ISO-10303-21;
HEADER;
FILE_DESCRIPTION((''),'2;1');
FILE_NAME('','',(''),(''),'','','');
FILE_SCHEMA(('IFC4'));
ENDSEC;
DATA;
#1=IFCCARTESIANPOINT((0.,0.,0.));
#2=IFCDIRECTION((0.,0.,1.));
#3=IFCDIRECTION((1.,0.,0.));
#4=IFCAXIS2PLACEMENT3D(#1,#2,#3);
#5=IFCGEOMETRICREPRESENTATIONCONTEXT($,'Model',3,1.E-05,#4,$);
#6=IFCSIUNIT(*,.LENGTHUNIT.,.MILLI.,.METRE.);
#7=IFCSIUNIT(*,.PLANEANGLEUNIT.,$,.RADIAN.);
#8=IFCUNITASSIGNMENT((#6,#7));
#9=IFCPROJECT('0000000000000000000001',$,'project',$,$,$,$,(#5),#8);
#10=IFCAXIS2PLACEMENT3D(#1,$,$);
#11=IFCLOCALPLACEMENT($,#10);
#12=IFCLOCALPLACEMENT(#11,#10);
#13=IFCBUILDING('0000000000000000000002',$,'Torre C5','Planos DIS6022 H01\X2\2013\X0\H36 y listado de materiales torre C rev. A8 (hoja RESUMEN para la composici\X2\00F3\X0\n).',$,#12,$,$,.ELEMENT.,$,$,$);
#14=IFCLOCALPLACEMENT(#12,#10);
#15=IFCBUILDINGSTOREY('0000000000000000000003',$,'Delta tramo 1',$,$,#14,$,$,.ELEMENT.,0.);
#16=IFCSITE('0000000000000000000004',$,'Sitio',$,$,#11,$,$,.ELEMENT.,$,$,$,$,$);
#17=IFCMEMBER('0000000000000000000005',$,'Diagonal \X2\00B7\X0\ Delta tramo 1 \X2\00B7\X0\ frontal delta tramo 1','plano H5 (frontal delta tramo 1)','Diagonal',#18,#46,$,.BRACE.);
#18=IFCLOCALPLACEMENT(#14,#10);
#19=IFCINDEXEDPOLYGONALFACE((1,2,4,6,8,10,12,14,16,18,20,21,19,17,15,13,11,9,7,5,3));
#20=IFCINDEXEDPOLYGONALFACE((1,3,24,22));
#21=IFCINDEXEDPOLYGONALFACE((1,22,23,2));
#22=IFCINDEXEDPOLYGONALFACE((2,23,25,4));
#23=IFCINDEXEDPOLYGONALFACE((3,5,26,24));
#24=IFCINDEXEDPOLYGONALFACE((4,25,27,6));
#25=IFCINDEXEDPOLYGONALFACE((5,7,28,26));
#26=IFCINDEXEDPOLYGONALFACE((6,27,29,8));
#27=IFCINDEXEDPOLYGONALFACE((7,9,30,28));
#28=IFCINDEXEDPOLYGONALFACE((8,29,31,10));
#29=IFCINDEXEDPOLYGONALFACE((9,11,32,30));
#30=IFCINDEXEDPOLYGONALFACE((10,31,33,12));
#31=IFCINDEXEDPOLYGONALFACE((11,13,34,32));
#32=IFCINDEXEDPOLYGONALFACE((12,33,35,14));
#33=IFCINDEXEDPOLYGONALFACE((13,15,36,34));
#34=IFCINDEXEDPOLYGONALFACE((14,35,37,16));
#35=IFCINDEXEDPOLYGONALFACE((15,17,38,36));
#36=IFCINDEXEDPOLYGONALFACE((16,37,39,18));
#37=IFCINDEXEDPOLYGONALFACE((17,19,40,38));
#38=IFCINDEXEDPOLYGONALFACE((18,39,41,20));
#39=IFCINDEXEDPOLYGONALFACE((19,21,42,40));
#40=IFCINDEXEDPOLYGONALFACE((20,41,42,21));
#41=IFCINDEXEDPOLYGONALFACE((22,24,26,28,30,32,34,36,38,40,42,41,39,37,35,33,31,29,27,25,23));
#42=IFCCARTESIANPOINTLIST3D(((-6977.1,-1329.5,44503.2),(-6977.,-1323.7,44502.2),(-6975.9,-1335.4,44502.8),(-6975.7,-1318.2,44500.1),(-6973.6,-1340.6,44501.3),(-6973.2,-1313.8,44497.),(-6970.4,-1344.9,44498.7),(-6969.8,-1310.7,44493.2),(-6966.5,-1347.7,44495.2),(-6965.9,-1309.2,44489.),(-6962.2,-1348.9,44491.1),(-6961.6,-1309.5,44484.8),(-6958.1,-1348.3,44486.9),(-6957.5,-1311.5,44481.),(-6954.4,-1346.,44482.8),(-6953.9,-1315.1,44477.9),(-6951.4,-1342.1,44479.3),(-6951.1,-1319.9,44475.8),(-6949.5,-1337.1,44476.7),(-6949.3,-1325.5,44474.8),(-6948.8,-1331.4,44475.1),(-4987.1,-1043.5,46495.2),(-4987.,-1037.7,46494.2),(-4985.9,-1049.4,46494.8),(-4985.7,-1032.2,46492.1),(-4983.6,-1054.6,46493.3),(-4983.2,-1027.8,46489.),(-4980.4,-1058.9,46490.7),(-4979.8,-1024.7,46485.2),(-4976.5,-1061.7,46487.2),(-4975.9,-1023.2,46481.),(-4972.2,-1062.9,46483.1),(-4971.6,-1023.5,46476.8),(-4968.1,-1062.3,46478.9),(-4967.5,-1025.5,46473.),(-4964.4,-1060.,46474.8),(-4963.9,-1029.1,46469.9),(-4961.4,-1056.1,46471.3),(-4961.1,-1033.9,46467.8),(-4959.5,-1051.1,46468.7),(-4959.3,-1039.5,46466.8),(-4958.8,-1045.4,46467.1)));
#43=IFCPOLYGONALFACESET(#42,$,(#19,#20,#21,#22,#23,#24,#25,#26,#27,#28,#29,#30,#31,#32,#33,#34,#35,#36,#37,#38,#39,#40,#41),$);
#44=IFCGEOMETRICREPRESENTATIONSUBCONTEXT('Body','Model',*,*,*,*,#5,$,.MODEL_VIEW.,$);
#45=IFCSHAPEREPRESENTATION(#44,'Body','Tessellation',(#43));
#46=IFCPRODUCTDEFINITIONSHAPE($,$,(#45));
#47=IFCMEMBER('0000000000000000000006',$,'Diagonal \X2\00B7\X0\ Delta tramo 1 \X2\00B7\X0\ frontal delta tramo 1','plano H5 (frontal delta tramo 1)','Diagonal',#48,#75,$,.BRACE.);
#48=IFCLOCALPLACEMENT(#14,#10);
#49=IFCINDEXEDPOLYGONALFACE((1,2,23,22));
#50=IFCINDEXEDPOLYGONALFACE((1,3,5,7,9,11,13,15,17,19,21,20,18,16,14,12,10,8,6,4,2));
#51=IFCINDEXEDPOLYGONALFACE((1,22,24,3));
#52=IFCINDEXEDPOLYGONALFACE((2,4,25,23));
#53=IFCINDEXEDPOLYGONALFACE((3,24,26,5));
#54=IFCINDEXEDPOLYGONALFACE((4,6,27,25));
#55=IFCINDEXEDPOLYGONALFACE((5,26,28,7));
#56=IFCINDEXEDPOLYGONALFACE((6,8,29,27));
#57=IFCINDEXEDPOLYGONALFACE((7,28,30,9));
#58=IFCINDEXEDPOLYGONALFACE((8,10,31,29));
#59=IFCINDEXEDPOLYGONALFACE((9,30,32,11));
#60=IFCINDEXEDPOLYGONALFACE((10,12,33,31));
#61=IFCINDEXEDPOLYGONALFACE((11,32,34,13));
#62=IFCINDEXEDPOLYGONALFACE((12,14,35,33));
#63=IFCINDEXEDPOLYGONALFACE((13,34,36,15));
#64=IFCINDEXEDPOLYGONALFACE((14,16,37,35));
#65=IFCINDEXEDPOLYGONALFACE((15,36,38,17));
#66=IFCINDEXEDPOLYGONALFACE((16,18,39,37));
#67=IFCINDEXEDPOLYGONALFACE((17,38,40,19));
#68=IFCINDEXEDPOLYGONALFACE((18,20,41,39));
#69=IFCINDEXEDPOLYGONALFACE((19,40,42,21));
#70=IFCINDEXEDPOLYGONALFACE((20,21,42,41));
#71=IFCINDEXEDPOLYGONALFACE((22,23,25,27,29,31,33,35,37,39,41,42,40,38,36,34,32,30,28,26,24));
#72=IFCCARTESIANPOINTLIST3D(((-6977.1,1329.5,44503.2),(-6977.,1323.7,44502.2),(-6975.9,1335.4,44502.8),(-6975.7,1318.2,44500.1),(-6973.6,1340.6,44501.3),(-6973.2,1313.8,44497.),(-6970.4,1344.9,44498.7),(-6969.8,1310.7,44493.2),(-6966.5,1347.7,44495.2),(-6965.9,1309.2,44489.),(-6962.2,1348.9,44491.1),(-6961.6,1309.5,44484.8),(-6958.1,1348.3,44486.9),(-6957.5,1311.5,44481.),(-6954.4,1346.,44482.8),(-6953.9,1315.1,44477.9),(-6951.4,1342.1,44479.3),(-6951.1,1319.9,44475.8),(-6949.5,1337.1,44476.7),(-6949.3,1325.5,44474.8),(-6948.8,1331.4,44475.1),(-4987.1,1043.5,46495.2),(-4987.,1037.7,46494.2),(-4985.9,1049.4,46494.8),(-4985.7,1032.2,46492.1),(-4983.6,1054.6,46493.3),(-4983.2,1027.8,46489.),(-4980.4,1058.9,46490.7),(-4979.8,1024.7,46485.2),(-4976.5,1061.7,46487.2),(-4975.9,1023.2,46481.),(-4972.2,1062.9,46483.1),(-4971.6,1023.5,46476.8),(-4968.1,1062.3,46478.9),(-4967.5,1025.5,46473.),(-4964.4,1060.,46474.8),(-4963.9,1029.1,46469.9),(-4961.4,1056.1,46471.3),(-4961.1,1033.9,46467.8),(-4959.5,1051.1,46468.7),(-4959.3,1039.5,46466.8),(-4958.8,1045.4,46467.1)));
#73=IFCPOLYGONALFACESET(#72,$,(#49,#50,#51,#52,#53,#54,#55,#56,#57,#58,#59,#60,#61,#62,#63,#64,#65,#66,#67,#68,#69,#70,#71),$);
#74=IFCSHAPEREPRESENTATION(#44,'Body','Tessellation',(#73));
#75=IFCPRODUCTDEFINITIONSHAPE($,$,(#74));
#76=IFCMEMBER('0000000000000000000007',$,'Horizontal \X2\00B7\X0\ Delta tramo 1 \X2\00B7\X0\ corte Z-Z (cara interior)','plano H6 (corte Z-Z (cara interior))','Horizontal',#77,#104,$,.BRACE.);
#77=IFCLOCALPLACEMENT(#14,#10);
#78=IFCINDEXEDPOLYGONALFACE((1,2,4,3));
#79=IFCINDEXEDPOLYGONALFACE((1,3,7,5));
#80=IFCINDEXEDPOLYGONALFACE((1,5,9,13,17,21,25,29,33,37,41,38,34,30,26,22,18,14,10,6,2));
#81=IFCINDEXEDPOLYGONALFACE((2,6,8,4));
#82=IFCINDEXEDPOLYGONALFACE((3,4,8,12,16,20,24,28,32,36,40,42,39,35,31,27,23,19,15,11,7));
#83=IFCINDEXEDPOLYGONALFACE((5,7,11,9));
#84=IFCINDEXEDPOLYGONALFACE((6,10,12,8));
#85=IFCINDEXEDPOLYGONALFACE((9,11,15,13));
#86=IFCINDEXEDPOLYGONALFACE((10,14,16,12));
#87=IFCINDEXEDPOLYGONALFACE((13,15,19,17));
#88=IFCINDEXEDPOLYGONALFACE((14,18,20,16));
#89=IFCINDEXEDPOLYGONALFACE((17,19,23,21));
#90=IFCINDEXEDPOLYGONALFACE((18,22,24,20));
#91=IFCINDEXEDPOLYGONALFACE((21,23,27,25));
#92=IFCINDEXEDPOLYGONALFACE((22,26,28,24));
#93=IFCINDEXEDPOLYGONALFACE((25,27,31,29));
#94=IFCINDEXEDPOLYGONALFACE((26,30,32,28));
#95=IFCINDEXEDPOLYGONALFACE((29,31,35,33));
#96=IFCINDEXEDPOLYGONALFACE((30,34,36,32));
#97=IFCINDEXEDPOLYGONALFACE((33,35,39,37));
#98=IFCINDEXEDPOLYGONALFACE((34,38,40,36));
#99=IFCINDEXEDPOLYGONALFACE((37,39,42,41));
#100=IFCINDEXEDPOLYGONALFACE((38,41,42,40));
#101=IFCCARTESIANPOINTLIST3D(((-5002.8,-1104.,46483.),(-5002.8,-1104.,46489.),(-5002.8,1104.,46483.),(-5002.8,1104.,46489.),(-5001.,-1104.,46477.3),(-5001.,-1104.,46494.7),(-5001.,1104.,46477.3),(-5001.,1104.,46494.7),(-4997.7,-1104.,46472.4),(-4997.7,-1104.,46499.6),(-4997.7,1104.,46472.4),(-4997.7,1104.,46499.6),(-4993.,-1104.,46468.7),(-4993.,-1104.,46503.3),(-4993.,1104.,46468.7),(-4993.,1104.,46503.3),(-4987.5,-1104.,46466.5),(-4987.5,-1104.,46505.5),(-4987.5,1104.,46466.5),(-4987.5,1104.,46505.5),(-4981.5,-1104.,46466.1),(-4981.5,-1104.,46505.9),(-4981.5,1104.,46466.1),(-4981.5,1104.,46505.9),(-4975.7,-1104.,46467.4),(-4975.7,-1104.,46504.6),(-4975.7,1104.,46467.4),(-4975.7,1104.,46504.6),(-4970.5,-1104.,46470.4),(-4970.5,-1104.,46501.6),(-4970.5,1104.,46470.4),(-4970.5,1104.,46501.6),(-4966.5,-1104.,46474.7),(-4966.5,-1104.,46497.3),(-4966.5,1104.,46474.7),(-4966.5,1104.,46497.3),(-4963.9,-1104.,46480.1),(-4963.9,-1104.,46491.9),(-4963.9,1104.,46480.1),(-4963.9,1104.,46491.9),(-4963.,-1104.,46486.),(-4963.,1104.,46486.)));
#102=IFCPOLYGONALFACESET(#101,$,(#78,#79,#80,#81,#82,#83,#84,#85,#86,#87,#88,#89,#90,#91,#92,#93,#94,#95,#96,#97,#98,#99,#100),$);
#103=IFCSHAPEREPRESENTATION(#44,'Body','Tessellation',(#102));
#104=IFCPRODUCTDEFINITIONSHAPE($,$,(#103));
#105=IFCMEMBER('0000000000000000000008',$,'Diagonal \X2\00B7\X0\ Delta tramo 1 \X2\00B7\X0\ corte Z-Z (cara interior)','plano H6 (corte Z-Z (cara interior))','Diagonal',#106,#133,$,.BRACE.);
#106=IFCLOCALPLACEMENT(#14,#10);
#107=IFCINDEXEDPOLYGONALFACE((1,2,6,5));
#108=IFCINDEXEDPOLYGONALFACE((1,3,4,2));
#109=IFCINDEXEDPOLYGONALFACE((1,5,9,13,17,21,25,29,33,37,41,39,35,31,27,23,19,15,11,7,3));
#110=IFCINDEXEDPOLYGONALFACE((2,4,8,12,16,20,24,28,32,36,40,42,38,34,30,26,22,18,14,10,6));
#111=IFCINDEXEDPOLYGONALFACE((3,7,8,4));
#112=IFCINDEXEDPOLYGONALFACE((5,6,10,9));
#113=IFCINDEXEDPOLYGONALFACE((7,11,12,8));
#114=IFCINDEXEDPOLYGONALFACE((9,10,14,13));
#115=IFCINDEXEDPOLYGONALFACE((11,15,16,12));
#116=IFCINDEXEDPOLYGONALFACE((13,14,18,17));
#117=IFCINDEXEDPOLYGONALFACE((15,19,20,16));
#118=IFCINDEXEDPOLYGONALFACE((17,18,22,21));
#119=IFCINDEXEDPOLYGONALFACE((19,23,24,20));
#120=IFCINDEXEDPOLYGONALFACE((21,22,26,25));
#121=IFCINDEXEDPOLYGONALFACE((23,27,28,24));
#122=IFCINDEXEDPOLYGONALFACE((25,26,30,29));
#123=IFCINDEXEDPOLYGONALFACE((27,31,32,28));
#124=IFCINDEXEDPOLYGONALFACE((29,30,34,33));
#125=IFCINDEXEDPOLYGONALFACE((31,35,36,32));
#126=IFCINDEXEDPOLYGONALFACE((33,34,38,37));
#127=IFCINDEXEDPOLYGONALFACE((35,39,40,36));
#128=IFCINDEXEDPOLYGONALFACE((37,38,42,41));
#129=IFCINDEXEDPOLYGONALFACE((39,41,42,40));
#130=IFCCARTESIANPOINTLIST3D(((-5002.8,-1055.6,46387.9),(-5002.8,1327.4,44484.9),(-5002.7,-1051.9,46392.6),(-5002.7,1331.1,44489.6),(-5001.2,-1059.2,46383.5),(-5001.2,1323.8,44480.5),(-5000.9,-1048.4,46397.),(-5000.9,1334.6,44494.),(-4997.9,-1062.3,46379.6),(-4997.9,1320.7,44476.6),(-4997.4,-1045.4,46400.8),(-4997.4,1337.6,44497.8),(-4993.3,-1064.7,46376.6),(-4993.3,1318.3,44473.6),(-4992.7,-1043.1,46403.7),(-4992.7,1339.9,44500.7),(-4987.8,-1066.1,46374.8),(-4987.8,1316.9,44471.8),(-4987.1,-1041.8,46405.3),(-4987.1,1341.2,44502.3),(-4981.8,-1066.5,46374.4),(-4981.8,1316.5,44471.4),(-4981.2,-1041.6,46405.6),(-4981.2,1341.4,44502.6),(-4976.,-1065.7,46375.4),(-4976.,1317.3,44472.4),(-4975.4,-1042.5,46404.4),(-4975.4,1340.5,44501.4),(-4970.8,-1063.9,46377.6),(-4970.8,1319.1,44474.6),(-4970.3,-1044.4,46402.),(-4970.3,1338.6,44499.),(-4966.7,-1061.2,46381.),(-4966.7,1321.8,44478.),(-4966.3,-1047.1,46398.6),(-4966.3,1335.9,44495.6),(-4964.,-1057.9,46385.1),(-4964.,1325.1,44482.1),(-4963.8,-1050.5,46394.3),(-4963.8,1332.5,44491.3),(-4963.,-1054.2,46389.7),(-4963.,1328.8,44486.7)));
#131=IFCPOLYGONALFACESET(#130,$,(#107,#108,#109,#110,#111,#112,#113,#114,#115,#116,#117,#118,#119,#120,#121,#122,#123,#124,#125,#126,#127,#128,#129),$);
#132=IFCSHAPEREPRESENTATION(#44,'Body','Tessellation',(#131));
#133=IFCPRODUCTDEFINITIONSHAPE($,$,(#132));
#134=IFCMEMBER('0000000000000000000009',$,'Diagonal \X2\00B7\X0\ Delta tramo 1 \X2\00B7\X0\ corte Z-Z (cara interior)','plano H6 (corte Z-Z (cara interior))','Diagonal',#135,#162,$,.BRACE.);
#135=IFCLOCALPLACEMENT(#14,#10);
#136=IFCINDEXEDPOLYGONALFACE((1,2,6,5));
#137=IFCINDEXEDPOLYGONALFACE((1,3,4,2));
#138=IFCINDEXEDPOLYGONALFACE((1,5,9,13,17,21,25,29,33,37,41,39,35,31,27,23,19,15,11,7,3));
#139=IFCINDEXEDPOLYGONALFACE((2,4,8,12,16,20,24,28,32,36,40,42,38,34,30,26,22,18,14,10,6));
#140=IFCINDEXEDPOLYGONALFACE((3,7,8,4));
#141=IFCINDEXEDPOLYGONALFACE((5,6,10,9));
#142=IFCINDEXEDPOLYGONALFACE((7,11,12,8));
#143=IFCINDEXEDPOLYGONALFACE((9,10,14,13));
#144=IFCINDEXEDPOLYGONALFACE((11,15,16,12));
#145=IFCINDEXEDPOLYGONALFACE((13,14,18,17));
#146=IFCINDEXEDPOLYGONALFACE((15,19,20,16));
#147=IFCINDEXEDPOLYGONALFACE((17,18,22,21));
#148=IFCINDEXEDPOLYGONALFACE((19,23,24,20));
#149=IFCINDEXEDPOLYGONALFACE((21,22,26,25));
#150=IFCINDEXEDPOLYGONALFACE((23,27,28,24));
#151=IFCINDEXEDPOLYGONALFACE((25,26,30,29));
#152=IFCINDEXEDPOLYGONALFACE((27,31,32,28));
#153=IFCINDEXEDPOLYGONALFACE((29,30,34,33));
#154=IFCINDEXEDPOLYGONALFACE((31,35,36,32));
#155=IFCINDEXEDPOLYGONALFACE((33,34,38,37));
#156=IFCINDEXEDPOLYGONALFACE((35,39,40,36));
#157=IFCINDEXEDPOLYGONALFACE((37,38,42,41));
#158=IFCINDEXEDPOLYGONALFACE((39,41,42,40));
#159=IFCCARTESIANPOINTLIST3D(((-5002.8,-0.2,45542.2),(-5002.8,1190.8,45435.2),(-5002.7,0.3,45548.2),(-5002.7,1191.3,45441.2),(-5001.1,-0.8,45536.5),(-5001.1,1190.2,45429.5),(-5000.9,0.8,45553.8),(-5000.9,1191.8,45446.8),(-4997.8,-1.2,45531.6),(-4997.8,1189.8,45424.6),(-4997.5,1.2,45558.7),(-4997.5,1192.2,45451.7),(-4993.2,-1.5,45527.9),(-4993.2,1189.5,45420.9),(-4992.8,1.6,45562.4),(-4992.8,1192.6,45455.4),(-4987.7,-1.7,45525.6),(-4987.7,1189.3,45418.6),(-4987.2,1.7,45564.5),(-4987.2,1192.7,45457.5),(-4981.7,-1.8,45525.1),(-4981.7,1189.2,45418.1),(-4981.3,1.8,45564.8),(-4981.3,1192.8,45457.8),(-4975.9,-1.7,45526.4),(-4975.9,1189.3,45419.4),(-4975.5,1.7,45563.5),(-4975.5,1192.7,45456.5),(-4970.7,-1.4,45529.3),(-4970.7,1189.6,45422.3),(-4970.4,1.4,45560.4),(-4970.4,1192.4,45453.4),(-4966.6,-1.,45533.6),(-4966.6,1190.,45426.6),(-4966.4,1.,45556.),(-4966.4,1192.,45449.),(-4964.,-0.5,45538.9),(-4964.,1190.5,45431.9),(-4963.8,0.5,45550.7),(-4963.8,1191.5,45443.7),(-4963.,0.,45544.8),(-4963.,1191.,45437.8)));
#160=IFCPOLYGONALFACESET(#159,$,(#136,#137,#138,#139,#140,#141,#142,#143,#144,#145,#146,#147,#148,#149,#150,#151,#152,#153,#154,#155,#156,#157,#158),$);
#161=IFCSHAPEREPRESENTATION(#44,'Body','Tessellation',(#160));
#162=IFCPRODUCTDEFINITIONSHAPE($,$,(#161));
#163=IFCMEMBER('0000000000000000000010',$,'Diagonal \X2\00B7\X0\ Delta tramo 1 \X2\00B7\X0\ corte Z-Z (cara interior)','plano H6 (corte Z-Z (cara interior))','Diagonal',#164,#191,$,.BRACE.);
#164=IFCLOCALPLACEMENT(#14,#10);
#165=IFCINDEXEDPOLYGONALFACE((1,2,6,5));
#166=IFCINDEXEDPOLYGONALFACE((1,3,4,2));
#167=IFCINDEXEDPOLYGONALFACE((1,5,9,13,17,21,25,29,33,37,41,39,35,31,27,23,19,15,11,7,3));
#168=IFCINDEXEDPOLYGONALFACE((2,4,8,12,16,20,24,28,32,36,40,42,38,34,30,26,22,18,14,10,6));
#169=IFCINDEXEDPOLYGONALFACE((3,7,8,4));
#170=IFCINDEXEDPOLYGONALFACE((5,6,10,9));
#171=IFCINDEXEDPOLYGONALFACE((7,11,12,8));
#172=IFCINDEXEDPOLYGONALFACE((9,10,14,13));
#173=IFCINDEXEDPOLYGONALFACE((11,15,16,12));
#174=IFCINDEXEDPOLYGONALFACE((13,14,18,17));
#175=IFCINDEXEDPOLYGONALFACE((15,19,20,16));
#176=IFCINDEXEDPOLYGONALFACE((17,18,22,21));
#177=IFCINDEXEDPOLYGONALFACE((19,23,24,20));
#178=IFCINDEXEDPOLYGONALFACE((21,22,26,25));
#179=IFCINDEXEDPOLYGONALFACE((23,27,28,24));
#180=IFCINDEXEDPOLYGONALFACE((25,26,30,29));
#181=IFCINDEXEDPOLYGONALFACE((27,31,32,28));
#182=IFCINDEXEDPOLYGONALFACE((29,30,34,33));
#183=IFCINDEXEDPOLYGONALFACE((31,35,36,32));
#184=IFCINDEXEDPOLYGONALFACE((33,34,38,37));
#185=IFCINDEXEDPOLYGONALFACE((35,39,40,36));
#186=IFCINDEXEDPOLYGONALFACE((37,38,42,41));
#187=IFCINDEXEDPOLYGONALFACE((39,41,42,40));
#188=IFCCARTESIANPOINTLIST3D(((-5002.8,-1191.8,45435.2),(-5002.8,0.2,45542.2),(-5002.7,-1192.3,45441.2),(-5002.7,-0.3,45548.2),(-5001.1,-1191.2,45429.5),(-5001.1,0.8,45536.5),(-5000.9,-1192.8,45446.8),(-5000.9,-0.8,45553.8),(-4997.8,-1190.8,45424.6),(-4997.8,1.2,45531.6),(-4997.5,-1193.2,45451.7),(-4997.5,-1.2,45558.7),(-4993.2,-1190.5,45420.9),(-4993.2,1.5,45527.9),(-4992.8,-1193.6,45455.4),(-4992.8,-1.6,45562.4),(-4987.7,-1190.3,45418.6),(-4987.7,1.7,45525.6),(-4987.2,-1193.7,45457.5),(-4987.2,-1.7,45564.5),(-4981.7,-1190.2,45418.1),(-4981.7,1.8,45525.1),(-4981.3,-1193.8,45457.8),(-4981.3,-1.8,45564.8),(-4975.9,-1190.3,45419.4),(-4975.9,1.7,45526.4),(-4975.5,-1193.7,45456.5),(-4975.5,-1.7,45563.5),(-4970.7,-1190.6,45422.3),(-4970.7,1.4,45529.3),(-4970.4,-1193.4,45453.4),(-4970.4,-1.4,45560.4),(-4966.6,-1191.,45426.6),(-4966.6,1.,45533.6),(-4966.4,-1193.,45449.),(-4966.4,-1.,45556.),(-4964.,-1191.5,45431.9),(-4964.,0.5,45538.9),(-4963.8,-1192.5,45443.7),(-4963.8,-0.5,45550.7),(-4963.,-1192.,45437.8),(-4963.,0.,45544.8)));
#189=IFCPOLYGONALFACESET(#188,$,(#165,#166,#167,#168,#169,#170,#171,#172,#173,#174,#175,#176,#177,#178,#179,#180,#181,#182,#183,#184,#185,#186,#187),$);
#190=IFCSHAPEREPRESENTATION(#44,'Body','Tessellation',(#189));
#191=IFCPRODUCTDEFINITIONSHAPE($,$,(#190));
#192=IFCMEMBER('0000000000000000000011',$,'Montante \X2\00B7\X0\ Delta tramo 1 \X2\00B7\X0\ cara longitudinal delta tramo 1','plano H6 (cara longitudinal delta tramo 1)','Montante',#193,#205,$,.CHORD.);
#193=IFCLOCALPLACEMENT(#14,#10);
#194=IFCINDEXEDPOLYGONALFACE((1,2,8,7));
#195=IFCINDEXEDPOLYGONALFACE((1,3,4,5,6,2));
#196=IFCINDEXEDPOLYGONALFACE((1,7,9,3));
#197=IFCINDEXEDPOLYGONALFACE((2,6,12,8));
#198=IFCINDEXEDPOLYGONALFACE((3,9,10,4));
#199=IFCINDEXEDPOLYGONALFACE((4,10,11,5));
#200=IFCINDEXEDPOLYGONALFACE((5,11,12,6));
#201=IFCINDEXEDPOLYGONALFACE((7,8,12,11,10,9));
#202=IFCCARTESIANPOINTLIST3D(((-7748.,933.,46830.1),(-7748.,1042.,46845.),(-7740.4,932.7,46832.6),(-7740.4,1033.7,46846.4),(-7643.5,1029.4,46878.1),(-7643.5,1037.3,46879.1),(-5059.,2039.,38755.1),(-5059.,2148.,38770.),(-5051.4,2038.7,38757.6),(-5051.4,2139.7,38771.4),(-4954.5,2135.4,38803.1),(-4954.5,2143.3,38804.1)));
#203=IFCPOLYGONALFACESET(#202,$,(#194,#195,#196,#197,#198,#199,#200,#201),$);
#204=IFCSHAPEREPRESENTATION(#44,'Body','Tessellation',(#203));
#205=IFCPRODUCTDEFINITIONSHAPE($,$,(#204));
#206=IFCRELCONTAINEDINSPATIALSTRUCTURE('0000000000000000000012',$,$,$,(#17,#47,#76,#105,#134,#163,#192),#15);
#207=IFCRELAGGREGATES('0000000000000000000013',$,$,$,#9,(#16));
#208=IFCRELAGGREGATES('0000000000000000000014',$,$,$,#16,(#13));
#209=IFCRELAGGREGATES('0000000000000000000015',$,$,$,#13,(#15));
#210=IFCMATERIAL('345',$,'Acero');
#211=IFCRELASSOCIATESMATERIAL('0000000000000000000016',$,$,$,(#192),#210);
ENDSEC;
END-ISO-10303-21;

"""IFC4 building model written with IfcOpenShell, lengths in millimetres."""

from ifc_helpers import new_model, si_unit, frame, frame_2d, origin, origin_with_axes, place, context, subcontext, project, spatial, circle, l_section, extrude, material, element, save


model = new_model("IFC4")

# Units and contexts
model_context = context("Model", 3, precision=1e-05, world=origin_with_axes())
body_context = subcontext(model_context, "Body", "Model", "MODEL_VIEW")
ifc_project = project(units=[si_unit("LENGTHUNIT", "METRE", prefix="MILLI"), si_unit("PLANEANGLEUNIT", "RADIAN")], contexts=[model_context])

# Site, building, storey
site_placement = place(None, origin())
site = spatial("IfcSite", under=ifc_project, at=site_placement, Name="Sitio", CompositionType="ELEMENT")
building_placement = place(site_placement, origin())
building = spatial("IfcBuilding", under=site, at=building_placement, Name="Torre C5", Description="Planos DIS6022 H01–H36 y listado de materiales torre C rev. A8 (hoja RESUMEN para la composición).", CompositionType="ELEMENT")
storey_placement = place(building_placement, origin())
storey = spatial("IfcBuildingStorey", under=building, at=storey_placement, Name="Delta tramo 1", CompositionType="ELEMENT", Elevation=0.0)

# Members
ifc_material = material(Name="345", Category="Acero")
for number, where, z_axis, x_axis, name in (
    (1, (-4973.0, -1043.0, 46481.0), (-0.703134, -0.101053, -0.70384), (0.683901, 0.174833, -0.708316), "Diagonal · Delta tramo 1 · frontal delta tramo 1"),
    (2, (-4973.0, 1043.0, 46481.0), (-0.703134, 0.101053, -0.70384), (0.683901, -0.174833, -0.708316), "Diagonal · Delta tramo 1 · frontal delta tramo 1"),
):
    element("IfcMember", number, at=place(storey_placement, frame(where, z_axis=z_axis, x_axis=x_axis)), inside=storey, Name=name, Description="plano H5 (frontal delta tramo 1)", ObjectType="Diagonal", PredefinedType="BRACE", context=body_context, shape_type="SweptSolid", body=[
        extrude(circle(Radius=20.0), None, (0.0, 0.0, 1.0), 2830.2),
    ])
member_1_placement = place(storey_placement, frame((-4983.0, -1104.0, 46486.0), z_axis=(0.0, 1.0, 0.0), x_axis=(1.0, 0.0, 0.0)))
element("IfcMember", 3, at=member_1_placement, inside=storey, Name="Horizontal · Delta tramo 1 · corte Z-Z (cara interior)", Description="plano H6 (corte Z-Z (cara interior))", ObjectType="Horizontal", PredefinedType="BRACE", context=body_context, shape_type="SweptSolid", body=[
    extrude(circle(Radius=20.0), None, (0.0, 0.0, 1.0), 2208.0),
])
member_2_placement = place(storey_placement, frame((-4983.0, -1054.0, 46390.0), z_axis=(0.0, 0.781412, -0.624015), x_axis=(0.999852, -0.010743, -0.013453)))
element("IfcMember", 4, at=member_2_placement, inside=storey, Name="Diagonal · Delta tramo 1 · corte Z-Z (cara interior)", Description="plano H6 (corte Z-Z (cara interior))", ObjectType="Diagonal", PredefinedType="BRACE", context=body_context, shape_type="SweptSolid", body=[
    extrude(circle(Radius=20.0), None, (0.0, 0.0, 1.0), 3049.6),
])
member_3_placement = place(storey_placement, frame((-4983.0, 1191.0, 45438.0), z_axis=(0.0, -0.995989, 0.08948), x_axis=(0.999943, -0.000957, -0.01065)))
element("IfcMember", 5, at=member_3_placement, inside=storey, Name="Diagonal · Delta tramo 1 · corte Z-Z (cara interior)", Description="plano H6 (corte Z-Z (cara interior))", ObjectType="Diagonal", PredefinedType="BRACE", context=body_context, shape_type="SweptSolid", body=[
    extrude(circle(Radius=20.0), None, (0.0, 0.0, 1.0), 1195.8),
])
member_4_placement = place(storey_placement, frame((-4983.0, -1192.0, 45438.0), z_axis=(0.0, 0.995995, 0.089406), x_axis=(0.999943, 0.000956, -0.01065)))
element("IfcMember", 6, at=member_4_placement, inside=storey, Name="Diagonal · Delta tramo 1 · corte Z-Z (cara interior)", Description="plano H6 (corte Z-Z (cara interior))", ObjectType="Diagonal", PredefinedType="BRACE", context=body_context, shape_type="SweptSolid", body=[
    extrude(circle(Radius=20.0), None, (0.0, 0.0, 1.0), 1196.8),
])
member_5_placement = place(storey_placement, frame((-7748.0, 1042.0, 46845.0), z_axis=(0.313311, 0.128867, -0.940866), x_axis=(0.94965, -0.042516, 0.310413)))
element("IfcMember", 7, at=member_5_placement, inside=storey, material=ifc_material, Name="Montante · Delta tramo 1 · cara longitudinal delta tramo 1", Description="plano H6 (cara longitudinal delta tramo 1)", ObjectType="Montante", PredefinedType="CHORD", context=body_context, shape_type="SweptSolid", body=[
    extrude(l_section(Depth=110.0, Width=110.0, Thickness=8.0, at=frame_2d((55.0, 55.0))), None, (0.0, 0.0, 1.0), 8582.5),
])

save(model, "model.ifc")
